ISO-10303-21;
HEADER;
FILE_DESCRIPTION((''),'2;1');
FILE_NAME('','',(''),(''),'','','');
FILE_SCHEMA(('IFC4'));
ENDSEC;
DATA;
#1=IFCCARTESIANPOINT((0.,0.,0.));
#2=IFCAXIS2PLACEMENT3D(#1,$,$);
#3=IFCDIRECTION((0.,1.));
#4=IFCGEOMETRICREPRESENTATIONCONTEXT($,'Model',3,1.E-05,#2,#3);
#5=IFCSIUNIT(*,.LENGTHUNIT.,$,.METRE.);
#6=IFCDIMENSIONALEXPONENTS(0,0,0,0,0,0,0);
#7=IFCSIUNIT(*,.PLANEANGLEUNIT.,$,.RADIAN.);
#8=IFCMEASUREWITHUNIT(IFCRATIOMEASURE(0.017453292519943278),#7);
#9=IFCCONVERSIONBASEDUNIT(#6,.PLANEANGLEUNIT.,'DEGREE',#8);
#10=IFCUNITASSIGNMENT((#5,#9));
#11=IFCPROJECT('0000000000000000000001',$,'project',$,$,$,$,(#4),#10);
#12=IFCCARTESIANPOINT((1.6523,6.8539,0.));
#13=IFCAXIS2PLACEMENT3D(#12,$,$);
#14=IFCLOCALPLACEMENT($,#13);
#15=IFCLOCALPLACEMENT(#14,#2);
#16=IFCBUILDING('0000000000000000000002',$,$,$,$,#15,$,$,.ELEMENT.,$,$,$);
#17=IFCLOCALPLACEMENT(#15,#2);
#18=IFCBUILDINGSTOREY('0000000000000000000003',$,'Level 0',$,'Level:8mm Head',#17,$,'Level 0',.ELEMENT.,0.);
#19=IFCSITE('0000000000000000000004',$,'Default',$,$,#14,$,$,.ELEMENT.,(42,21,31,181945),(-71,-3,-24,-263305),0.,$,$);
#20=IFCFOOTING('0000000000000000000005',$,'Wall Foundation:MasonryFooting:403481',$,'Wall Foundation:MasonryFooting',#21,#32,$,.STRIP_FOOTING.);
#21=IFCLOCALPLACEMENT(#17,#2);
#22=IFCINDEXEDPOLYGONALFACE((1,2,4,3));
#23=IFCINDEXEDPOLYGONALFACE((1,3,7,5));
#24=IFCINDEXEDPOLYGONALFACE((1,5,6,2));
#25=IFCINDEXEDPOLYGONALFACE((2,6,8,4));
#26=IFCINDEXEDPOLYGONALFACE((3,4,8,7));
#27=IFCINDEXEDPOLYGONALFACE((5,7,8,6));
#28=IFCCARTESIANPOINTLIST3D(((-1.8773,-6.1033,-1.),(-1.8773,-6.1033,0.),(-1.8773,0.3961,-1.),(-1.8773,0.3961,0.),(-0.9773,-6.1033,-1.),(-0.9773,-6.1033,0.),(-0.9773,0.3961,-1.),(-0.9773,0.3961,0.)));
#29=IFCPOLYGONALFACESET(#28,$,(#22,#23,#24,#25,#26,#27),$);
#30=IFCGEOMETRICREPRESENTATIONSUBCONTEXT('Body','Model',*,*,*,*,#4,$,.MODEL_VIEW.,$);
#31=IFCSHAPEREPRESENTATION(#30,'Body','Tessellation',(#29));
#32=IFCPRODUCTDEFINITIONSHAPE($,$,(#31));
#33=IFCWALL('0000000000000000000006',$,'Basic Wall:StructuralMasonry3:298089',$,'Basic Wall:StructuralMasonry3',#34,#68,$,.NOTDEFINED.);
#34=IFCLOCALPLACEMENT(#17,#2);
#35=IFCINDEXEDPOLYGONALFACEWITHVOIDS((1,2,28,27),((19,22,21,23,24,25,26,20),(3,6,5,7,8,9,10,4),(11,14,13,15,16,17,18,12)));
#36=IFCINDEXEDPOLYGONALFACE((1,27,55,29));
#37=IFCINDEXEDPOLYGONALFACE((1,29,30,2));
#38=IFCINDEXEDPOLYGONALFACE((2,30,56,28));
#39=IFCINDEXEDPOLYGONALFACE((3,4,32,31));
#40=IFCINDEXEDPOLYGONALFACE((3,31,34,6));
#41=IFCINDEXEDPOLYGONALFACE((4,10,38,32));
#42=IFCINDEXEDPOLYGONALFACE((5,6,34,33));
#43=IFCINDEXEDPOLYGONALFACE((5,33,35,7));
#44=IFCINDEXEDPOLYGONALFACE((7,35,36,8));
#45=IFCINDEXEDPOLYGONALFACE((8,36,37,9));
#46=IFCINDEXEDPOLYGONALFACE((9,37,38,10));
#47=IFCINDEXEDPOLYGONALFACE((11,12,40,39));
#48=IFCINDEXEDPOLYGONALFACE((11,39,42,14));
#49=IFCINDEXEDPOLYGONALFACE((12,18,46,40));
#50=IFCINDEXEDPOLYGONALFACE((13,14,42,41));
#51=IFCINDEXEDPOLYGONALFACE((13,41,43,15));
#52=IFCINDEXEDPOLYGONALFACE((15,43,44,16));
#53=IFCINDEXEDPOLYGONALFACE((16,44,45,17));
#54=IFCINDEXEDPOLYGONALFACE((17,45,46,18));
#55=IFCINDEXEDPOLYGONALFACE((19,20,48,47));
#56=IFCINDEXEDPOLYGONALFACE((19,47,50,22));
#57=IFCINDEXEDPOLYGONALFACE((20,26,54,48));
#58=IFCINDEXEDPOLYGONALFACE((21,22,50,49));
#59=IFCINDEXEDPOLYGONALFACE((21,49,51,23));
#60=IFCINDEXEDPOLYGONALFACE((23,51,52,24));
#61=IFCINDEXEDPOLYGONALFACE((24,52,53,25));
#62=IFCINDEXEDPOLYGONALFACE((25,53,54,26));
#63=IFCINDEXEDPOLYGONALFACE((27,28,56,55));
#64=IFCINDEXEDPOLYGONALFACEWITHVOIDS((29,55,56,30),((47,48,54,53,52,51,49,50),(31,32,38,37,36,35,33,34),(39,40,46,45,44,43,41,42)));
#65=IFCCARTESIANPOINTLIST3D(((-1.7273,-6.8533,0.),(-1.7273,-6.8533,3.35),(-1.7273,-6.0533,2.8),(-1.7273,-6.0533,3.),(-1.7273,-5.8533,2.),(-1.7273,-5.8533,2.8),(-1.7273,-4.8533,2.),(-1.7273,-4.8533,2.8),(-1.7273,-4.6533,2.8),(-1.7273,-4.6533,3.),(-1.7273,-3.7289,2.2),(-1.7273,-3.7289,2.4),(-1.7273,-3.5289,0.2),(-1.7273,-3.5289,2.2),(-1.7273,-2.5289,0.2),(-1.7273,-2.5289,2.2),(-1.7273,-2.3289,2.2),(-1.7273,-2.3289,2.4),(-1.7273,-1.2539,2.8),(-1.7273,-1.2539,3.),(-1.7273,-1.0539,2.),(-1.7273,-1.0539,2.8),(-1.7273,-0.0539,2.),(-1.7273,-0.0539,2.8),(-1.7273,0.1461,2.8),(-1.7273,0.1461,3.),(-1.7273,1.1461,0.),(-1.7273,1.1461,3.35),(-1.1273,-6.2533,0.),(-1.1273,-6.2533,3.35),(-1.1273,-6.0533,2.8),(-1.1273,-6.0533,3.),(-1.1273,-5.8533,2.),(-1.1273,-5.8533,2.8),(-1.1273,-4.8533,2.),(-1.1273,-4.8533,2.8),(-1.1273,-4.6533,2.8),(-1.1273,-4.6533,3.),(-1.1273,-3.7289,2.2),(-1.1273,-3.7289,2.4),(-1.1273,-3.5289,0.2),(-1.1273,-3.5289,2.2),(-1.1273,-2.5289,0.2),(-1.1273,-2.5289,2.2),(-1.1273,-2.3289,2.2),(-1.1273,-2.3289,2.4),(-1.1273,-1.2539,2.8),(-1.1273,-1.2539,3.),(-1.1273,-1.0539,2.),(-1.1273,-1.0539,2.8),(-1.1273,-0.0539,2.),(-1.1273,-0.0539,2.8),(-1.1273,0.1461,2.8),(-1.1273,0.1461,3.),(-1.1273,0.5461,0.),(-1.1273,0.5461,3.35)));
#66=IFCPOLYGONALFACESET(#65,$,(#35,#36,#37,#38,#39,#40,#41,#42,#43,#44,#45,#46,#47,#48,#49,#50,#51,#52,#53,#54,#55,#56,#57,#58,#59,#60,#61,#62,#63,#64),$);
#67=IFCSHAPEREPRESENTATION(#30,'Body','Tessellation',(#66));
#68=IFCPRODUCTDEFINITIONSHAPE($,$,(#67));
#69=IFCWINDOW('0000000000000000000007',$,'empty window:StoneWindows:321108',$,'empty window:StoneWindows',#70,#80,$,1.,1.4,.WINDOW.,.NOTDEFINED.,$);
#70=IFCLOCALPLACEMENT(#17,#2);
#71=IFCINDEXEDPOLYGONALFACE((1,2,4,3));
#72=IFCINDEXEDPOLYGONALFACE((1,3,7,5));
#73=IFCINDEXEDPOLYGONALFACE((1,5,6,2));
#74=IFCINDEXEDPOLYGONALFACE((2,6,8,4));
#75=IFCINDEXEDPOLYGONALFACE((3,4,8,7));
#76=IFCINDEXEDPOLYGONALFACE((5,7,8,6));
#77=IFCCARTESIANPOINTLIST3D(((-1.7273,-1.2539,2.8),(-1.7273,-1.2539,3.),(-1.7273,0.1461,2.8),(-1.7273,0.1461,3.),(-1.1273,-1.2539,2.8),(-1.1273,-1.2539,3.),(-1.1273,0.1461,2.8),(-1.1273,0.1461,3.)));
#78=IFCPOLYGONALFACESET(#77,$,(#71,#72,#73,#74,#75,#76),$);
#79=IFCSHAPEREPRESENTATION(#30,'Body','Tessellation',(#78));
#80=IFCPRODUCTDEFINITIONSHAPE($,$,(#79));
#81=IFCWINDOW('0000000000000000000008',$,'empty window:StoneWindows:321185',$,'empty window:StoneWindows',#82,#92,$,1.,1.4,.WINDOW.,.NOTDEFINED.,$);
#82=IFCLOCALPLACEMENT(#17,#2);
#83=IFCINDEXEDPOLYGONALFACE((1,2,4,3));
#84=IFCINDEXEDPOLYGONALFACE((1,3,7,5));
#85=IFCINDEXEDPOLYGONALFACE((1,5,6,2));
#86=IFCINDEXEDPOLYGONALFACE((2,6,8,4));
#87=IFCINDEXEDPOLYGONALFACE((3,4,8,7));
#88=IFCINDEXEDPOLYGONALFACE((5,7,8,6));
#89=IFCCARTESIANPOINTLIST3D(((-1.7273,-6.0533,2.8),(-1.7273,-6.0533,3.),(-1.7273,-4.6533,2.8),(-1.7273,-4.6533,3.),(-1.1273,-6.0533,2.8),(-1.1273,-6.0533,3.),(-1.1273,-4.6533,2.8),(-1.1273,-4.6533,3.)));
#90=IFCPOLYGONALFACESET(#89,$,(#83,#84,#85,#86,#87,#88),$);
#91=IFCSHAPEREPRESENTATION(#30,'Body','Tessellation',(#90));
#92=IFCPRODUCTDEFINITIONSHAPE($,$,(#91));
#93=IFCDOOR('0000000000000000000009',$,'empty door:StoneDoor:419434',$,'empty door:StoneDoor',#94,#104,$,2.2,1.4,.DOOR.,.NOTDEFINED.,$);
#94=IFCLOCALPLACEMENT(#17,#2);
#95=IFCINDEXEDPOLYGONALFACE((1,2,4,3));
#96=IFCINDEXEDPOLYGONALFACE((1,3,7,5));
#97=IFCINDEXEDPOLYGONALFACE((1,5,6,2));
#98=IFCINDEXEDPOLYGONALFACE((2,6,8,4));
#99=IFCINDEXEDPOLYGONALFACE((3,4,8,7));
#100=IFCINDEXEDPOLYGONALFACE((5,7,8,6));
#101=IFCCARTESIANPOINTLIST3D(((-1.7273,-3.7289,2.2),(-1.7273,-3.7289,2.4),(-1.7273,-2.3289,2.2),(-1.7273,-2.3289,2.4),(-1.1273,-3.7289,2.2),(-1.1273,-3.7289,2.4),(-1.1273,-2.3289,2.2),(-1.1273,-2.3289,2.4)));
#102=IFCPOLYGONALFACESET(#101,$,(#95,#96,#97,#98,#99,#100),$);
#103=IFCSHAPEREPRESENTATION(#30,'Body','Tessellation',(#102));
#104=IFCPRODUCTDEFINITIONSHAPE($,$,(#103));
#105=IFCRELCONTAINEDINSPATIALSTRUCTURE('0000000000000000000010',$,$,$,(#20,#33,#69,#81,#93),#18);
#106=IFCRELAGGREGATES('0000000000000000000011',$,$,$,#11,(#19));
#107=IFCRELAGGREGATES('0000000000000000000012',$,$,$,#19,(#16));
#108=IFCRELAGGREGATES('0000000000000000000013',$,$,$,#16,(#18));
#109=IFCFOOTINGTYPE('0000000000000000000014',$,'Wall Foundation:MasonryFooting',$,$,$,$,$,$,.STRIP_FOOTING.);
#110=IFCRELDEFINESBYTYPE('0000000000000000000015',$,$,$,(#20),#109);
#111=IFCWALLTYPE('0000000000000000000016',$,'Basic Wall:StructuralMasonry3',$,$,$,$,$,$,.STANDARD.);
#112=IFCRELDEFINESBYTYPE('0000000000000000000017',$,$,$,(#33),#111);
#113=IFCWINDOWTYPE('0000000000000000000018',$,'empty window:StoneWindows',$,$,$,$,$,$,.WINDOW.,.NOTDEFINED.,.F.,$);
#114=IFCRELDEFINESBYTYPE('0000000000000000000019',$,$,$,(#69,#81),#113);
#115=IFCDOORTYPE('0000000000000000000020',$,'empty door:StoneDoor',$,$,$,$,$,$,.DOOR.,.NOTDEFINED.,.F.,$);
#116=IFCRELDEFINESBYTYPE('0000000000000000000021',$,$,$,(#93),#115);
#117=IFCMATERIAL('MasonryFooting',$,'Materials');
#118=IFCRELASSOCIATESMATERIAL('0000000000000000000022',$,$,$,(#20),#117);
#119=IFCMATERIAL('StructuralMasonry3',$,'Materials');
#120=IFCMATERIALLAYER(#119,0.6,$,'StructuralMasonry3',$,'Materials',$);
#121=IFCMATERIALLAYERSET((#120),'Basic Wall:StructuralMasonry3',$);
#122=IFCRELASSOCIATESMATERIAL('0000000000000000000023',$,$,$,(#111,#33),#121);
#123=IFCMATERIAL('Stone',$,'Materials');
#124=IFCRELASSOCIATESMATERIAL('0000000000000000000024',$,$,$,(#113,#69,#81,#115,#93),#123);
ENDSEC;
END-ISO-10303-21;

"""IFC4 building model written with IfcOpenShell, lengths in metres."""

from ifc_helpers import new_model, entity, si_unit, converted_unit, direction, frame, frame_2d, origin, origin_2d_with_axis, place, context, subcontext, project, spatial, polyline, rectangle, outline, extrude, source, transform, mapped, material, layer, layer_set, layer_usage, type_object, type_shapes, element, fill, save


model = new_model("IFC4")

# Units and contexts
model_context = context("Model", 3, precision=1e-05, world=origin(), true_north=direction((0.0, 1.0)))
body_context = subcontext(model_context, "Body", "Model", "MODEL_VIEW")
ifc_project = project(units=[si_unit("LENGTHUNIT", "METRE"), converted_unit("PLANEANGLEUNIT", "DEGREE", entity("IfcRatioMeasure", 0.017453292519943278), si_unit("PLANEANGLEUNIT", "RADIAN"), dimensions=[0, 0, 0, 0, 0, 0, 0])], contexts=[model_context])

# Site, building, storey
site_placement = place(None, frame((1.6523, 6.8539, 0.0)))
site = spatial("IfcSite", under=ifc_project, at=site_placement, Name="Default", CompositionType="ELEMENT", RefLatitude=(42, 21, 31, 181945), RefLongitude=(-71, -3, -24, -263305), RefElevation=0.0)
building_placement = place(site_placement, origin())
building = spatial("IfcBuilding", under=site, at=building_placement, CompositionType="ELEMENT")
storey_placement = place(building_placement, origin())
storey = spatial("IfcBuildingStorey", under=building, at=storey_placement, Name="Level 0", ObjectType="Level:8mm Head", LongName="Level 0", CompositionType="ELEMENT", Elevation=0.0)

# Footing
ifc_material_1 = material(Name="MasonryFooting", Category="Materials")
footing_type = type_object("IfcFootingType", Name="Wall Foundation:MasonryFooting", PredefinedType="STRIP_FOOTING")
footing_1_placement = place(storey_placement, frame((-1.8773, -6.1033, -1.0)))
element("IfcFooting", 1, at=footing_1_placement, inside=storey, type_object=footing_type, material=ifc_material_1, Name="Wall Foundation:MasonryFooting:403481", ObjectType="Wall Foundation:MasonryFooting", PredefinedType="STRIP_FOOTING", context=body_context, shape_type="SweptSolid", body=[
    extrude(rectangle(XDim=6.4994, YDim=0.9, at=frame_2d((0.0, 0.0), x_axis=(1.0, 0.0))), frame((0.45, 3.2497, 0.0), z_axis=(0.0, 0.0, 1.0), x_axis=(0.0, 1.0, 0.0)), (0.0, 0.0, 1.0), 1.0),
])

# Wall, openings, windows, door
ifc_material_2 = material(Name="StructuralMasonry3", Category="Materials")
ifc_layer = layer(ifc_material_2, 0.6, Name="StructuralMasonry3", Category="Materials")
ifc_layer_set = layer_set([ifc_layer], Name="Basic Wall:StructuralMasonry3")
ifc_layer_usage = layer_usage(ifc_layer_set, "AXIS2", "NEGATIVE", 0.3)
wall_type = type_object("IfcWallType", Name="Basic Wall:StructuralMasonry3", PredefinedType="STANDARD", material=ifc_layer_set)
wall_1_placement = place(storey_placement, frame((-1.4273, -6.8533, 0.0), z_axis=(0.0, 0.0, 1.0), x_axis=(0.0, 1.0, 0.0)))
wall_1 = element("IfcWall", 2, at=wall_1_placement, inside=storey, type_object=wall_type, material=ifc_layer_usage, Name="Basic Wall:StructuralMasonry3:298089", ObjectType="Basic Wall:StructuralMasonry3", PredefinedType="NOTDEFINED", context=body_context, shape_type="SweptSolid", body=[
    extrude(outline(polyline([(7.3994, -0.3), (7.9994, 0.3), (0.0, 0.3), (0.6, -0.3), (7.3994, -0.3)])), origin(), (0.0, 0.0, 1.0), 3.35),
])
opening_1_placement = place(wall_1_placement, frame((3.1244, -0.3, 0.2)))
opening_1 = element("IfcOpeningElement", 3, at=opening_1_placement, cuts=wall_1, PredefinedType="OPENING", context=body_context, shape_type="SweptSolid", body=[
    extrude(outline(polyline([(0.0, 1.2), (0.0, 0.2), (2.0, 0.2), (2.0, 0.0), (2.2, 0.0), (2.2, 1.4), (2.0, 1.4), (2.0, 1.2), (0.0, 1.2)])), frame((0.0, 0.0, 0.0), z_axis=(0.0, 1.0, 0.0), x_axis=(0.0, 0.0, 1.0)), (0.0, 0.0, 1.0), 0.6),
])
opening_2_placement = place(wall_1_placement, frame((2.2, 0.3, 2.0)))
opening_2 = element("IfcOpeningElement", 4, at=opening_2_placement, cuts=wall_1, PredefinedType="OPENING", context=body_context, shape_type="SweptSolid", body=[
    extrude(outline(polyline([(0.0, 0.2), (0.8, 0.2), (0.8, 0.0), (1.0, 0.0), (1.0, 1.4), (0.8, 1.4), (0.8, 1.2), (0.0, 1.2), (0.0, 0.2)])), frame((0.0, 0.0, 0.0), z_axis=(0.0, -1.0, 0.0), x_axis=(0.0, 0.0, 1.0)), (0.0, 0.0, 1.0), 0.6),
])
opening_3_placement = place(wall_1_placement, frame((6.9994, 0.3, 2.0)))
opening_3 = element("IfcOpeningElement", 5, at=opening_3_placement, cuts=wall_1, PredefinedType="OPENING", context=body_context, shape_type="SweptSolid", body=[
    extrude(outline(polyline([(0.0, 0.2), (0.8, 0.2), (0.8, 0.0), (1.0, 0.0), (1.0, 1.4), (0.8, 1.4), (0.8, 1.2), (0.0, 1.2), (0.0, 0.2)])), frame((0.0, 0.0, 0.0), z_axis=(0.0, -1.0, 0.0), x_axis=(0.0, 0.0, 1.0)), (0.0, 0.0, 1.0), 0.6),
])
ifc_material_3 = material(Name="Stone", Category="Materials")
window_type = type_object("IfcWindowType", Name="empty window:StoneWindows", ParameterTakesPrecedence=False, PartitioningType="NOTDEFINED", PredefinedType="WINDOW", material=ifc_material_3)
shared_shape_1 = source(origin(), body_context, "Body", "SweptSolid", [
    extrude(rectangle(XDim=0.2, YDim=1.4, at=frame_2d((-0.1, 0.02), x_axis=(0.0, 1.0))), frame((0.6, 0.0, 0.88), z_axis=(0.0, 1.0, 0.0), x_axis=(-1.0, 0.0, 0.0)), (0.0, 0.0, 1.0), 0.6),
])
type_shapes(window_type, [shared_shape_1])
window_1_placement = place(opening_3_placement, frame((0.0, 0.0, 0.0), z_axis=(0.0, 0.0, 1.0), x_axis=(-1.0, 0.0, 0.0)))
window_1 = element("IfcWindow", 6, at=window_1_placement, inside=storey, type_object=window_type, material=ifc_material_3, Name="empty window:StoneWindows:321108", ObjectType="empty window:StoneWindows", OverallHeight=1.0, OverallWidth=1.4, PartitioningType="NOTDEFINED", PredefinedType="WINDOW", context=body_context, shape_type="MappedRepresentation", body=[
    mapped(shared_shape_1, transform((0.0, 0.0, 0.0), scale=1.0)),
])
fill(opening_3, window_1)
window_2_placement = place(opening_2_placement, frame((0.0, 0.0, 0.0), z_axis=(0.0, 0.0, 1.0), x_axis=(-1.0, 0.0, 0.0)))
window_2 = element("IfcWindow", 7, at=window_2_placement, inside=storey, type_object=window_type, material=ifc_material_3, Name="empty window:StoneWindows:321185", ObjectType="empty window:StoneWindows", OverallHeight=1.0, OverallWidth=1.4, PartitioningType="NOTDEFINED", PredefinedType="WINDOW", context=body_context, shape_type="MappedRepresentation", body=[
    mapped(shared_shape_1, transform((0.0, 0.0, 0.0), scale=1.0)),
])
fill(opening_2, window_2)
door_type_1 = type_object("IfcDoorType", Name="empty door:StoneDoor", OperationType="NOTDEFINED", ParameterTakesPrecedence=False, PredefinedType="DOOR", material=ifc_material_3)
shared_shape_2 = source(origin(), body_context, "Body", "SweptSolid", [
    extrude(rectangle(XDim=0.6, YDim=1.4, at=origin_2d_with_axis()), frame((0.7, 0.3, 2.0), z_axis=(0.0, 0.0, 1.0), x_axis=(0.0, 1.0, 0.0)), (0.0, 0.0, 1.0), 0.2),
])
type_shapes(door_type_1, [shared_shape_2])
door_1_placement = place(opening_1_placement, origin())
door_1 = element("IfcDoor", 8, at=door_1_placement, inside=storey, type_object=door_type_1, material=ifc_material_3, Name="empty door:StoneDoor:419434", ObjectType="empty door:StoneDoor", OperationType="NOTDEFINED", OverallHeight=2.2, OverallWidth=1.4, PredefinedType="DOOR", context=body_context, shape_type="MappedRepresentation", body=[
    mapped(shared_shape_2, transform((0.0, 0.0, 0.0), scale=1.0)),
])
fill(opening_1, door_1)

save(model, "model.ifc")
